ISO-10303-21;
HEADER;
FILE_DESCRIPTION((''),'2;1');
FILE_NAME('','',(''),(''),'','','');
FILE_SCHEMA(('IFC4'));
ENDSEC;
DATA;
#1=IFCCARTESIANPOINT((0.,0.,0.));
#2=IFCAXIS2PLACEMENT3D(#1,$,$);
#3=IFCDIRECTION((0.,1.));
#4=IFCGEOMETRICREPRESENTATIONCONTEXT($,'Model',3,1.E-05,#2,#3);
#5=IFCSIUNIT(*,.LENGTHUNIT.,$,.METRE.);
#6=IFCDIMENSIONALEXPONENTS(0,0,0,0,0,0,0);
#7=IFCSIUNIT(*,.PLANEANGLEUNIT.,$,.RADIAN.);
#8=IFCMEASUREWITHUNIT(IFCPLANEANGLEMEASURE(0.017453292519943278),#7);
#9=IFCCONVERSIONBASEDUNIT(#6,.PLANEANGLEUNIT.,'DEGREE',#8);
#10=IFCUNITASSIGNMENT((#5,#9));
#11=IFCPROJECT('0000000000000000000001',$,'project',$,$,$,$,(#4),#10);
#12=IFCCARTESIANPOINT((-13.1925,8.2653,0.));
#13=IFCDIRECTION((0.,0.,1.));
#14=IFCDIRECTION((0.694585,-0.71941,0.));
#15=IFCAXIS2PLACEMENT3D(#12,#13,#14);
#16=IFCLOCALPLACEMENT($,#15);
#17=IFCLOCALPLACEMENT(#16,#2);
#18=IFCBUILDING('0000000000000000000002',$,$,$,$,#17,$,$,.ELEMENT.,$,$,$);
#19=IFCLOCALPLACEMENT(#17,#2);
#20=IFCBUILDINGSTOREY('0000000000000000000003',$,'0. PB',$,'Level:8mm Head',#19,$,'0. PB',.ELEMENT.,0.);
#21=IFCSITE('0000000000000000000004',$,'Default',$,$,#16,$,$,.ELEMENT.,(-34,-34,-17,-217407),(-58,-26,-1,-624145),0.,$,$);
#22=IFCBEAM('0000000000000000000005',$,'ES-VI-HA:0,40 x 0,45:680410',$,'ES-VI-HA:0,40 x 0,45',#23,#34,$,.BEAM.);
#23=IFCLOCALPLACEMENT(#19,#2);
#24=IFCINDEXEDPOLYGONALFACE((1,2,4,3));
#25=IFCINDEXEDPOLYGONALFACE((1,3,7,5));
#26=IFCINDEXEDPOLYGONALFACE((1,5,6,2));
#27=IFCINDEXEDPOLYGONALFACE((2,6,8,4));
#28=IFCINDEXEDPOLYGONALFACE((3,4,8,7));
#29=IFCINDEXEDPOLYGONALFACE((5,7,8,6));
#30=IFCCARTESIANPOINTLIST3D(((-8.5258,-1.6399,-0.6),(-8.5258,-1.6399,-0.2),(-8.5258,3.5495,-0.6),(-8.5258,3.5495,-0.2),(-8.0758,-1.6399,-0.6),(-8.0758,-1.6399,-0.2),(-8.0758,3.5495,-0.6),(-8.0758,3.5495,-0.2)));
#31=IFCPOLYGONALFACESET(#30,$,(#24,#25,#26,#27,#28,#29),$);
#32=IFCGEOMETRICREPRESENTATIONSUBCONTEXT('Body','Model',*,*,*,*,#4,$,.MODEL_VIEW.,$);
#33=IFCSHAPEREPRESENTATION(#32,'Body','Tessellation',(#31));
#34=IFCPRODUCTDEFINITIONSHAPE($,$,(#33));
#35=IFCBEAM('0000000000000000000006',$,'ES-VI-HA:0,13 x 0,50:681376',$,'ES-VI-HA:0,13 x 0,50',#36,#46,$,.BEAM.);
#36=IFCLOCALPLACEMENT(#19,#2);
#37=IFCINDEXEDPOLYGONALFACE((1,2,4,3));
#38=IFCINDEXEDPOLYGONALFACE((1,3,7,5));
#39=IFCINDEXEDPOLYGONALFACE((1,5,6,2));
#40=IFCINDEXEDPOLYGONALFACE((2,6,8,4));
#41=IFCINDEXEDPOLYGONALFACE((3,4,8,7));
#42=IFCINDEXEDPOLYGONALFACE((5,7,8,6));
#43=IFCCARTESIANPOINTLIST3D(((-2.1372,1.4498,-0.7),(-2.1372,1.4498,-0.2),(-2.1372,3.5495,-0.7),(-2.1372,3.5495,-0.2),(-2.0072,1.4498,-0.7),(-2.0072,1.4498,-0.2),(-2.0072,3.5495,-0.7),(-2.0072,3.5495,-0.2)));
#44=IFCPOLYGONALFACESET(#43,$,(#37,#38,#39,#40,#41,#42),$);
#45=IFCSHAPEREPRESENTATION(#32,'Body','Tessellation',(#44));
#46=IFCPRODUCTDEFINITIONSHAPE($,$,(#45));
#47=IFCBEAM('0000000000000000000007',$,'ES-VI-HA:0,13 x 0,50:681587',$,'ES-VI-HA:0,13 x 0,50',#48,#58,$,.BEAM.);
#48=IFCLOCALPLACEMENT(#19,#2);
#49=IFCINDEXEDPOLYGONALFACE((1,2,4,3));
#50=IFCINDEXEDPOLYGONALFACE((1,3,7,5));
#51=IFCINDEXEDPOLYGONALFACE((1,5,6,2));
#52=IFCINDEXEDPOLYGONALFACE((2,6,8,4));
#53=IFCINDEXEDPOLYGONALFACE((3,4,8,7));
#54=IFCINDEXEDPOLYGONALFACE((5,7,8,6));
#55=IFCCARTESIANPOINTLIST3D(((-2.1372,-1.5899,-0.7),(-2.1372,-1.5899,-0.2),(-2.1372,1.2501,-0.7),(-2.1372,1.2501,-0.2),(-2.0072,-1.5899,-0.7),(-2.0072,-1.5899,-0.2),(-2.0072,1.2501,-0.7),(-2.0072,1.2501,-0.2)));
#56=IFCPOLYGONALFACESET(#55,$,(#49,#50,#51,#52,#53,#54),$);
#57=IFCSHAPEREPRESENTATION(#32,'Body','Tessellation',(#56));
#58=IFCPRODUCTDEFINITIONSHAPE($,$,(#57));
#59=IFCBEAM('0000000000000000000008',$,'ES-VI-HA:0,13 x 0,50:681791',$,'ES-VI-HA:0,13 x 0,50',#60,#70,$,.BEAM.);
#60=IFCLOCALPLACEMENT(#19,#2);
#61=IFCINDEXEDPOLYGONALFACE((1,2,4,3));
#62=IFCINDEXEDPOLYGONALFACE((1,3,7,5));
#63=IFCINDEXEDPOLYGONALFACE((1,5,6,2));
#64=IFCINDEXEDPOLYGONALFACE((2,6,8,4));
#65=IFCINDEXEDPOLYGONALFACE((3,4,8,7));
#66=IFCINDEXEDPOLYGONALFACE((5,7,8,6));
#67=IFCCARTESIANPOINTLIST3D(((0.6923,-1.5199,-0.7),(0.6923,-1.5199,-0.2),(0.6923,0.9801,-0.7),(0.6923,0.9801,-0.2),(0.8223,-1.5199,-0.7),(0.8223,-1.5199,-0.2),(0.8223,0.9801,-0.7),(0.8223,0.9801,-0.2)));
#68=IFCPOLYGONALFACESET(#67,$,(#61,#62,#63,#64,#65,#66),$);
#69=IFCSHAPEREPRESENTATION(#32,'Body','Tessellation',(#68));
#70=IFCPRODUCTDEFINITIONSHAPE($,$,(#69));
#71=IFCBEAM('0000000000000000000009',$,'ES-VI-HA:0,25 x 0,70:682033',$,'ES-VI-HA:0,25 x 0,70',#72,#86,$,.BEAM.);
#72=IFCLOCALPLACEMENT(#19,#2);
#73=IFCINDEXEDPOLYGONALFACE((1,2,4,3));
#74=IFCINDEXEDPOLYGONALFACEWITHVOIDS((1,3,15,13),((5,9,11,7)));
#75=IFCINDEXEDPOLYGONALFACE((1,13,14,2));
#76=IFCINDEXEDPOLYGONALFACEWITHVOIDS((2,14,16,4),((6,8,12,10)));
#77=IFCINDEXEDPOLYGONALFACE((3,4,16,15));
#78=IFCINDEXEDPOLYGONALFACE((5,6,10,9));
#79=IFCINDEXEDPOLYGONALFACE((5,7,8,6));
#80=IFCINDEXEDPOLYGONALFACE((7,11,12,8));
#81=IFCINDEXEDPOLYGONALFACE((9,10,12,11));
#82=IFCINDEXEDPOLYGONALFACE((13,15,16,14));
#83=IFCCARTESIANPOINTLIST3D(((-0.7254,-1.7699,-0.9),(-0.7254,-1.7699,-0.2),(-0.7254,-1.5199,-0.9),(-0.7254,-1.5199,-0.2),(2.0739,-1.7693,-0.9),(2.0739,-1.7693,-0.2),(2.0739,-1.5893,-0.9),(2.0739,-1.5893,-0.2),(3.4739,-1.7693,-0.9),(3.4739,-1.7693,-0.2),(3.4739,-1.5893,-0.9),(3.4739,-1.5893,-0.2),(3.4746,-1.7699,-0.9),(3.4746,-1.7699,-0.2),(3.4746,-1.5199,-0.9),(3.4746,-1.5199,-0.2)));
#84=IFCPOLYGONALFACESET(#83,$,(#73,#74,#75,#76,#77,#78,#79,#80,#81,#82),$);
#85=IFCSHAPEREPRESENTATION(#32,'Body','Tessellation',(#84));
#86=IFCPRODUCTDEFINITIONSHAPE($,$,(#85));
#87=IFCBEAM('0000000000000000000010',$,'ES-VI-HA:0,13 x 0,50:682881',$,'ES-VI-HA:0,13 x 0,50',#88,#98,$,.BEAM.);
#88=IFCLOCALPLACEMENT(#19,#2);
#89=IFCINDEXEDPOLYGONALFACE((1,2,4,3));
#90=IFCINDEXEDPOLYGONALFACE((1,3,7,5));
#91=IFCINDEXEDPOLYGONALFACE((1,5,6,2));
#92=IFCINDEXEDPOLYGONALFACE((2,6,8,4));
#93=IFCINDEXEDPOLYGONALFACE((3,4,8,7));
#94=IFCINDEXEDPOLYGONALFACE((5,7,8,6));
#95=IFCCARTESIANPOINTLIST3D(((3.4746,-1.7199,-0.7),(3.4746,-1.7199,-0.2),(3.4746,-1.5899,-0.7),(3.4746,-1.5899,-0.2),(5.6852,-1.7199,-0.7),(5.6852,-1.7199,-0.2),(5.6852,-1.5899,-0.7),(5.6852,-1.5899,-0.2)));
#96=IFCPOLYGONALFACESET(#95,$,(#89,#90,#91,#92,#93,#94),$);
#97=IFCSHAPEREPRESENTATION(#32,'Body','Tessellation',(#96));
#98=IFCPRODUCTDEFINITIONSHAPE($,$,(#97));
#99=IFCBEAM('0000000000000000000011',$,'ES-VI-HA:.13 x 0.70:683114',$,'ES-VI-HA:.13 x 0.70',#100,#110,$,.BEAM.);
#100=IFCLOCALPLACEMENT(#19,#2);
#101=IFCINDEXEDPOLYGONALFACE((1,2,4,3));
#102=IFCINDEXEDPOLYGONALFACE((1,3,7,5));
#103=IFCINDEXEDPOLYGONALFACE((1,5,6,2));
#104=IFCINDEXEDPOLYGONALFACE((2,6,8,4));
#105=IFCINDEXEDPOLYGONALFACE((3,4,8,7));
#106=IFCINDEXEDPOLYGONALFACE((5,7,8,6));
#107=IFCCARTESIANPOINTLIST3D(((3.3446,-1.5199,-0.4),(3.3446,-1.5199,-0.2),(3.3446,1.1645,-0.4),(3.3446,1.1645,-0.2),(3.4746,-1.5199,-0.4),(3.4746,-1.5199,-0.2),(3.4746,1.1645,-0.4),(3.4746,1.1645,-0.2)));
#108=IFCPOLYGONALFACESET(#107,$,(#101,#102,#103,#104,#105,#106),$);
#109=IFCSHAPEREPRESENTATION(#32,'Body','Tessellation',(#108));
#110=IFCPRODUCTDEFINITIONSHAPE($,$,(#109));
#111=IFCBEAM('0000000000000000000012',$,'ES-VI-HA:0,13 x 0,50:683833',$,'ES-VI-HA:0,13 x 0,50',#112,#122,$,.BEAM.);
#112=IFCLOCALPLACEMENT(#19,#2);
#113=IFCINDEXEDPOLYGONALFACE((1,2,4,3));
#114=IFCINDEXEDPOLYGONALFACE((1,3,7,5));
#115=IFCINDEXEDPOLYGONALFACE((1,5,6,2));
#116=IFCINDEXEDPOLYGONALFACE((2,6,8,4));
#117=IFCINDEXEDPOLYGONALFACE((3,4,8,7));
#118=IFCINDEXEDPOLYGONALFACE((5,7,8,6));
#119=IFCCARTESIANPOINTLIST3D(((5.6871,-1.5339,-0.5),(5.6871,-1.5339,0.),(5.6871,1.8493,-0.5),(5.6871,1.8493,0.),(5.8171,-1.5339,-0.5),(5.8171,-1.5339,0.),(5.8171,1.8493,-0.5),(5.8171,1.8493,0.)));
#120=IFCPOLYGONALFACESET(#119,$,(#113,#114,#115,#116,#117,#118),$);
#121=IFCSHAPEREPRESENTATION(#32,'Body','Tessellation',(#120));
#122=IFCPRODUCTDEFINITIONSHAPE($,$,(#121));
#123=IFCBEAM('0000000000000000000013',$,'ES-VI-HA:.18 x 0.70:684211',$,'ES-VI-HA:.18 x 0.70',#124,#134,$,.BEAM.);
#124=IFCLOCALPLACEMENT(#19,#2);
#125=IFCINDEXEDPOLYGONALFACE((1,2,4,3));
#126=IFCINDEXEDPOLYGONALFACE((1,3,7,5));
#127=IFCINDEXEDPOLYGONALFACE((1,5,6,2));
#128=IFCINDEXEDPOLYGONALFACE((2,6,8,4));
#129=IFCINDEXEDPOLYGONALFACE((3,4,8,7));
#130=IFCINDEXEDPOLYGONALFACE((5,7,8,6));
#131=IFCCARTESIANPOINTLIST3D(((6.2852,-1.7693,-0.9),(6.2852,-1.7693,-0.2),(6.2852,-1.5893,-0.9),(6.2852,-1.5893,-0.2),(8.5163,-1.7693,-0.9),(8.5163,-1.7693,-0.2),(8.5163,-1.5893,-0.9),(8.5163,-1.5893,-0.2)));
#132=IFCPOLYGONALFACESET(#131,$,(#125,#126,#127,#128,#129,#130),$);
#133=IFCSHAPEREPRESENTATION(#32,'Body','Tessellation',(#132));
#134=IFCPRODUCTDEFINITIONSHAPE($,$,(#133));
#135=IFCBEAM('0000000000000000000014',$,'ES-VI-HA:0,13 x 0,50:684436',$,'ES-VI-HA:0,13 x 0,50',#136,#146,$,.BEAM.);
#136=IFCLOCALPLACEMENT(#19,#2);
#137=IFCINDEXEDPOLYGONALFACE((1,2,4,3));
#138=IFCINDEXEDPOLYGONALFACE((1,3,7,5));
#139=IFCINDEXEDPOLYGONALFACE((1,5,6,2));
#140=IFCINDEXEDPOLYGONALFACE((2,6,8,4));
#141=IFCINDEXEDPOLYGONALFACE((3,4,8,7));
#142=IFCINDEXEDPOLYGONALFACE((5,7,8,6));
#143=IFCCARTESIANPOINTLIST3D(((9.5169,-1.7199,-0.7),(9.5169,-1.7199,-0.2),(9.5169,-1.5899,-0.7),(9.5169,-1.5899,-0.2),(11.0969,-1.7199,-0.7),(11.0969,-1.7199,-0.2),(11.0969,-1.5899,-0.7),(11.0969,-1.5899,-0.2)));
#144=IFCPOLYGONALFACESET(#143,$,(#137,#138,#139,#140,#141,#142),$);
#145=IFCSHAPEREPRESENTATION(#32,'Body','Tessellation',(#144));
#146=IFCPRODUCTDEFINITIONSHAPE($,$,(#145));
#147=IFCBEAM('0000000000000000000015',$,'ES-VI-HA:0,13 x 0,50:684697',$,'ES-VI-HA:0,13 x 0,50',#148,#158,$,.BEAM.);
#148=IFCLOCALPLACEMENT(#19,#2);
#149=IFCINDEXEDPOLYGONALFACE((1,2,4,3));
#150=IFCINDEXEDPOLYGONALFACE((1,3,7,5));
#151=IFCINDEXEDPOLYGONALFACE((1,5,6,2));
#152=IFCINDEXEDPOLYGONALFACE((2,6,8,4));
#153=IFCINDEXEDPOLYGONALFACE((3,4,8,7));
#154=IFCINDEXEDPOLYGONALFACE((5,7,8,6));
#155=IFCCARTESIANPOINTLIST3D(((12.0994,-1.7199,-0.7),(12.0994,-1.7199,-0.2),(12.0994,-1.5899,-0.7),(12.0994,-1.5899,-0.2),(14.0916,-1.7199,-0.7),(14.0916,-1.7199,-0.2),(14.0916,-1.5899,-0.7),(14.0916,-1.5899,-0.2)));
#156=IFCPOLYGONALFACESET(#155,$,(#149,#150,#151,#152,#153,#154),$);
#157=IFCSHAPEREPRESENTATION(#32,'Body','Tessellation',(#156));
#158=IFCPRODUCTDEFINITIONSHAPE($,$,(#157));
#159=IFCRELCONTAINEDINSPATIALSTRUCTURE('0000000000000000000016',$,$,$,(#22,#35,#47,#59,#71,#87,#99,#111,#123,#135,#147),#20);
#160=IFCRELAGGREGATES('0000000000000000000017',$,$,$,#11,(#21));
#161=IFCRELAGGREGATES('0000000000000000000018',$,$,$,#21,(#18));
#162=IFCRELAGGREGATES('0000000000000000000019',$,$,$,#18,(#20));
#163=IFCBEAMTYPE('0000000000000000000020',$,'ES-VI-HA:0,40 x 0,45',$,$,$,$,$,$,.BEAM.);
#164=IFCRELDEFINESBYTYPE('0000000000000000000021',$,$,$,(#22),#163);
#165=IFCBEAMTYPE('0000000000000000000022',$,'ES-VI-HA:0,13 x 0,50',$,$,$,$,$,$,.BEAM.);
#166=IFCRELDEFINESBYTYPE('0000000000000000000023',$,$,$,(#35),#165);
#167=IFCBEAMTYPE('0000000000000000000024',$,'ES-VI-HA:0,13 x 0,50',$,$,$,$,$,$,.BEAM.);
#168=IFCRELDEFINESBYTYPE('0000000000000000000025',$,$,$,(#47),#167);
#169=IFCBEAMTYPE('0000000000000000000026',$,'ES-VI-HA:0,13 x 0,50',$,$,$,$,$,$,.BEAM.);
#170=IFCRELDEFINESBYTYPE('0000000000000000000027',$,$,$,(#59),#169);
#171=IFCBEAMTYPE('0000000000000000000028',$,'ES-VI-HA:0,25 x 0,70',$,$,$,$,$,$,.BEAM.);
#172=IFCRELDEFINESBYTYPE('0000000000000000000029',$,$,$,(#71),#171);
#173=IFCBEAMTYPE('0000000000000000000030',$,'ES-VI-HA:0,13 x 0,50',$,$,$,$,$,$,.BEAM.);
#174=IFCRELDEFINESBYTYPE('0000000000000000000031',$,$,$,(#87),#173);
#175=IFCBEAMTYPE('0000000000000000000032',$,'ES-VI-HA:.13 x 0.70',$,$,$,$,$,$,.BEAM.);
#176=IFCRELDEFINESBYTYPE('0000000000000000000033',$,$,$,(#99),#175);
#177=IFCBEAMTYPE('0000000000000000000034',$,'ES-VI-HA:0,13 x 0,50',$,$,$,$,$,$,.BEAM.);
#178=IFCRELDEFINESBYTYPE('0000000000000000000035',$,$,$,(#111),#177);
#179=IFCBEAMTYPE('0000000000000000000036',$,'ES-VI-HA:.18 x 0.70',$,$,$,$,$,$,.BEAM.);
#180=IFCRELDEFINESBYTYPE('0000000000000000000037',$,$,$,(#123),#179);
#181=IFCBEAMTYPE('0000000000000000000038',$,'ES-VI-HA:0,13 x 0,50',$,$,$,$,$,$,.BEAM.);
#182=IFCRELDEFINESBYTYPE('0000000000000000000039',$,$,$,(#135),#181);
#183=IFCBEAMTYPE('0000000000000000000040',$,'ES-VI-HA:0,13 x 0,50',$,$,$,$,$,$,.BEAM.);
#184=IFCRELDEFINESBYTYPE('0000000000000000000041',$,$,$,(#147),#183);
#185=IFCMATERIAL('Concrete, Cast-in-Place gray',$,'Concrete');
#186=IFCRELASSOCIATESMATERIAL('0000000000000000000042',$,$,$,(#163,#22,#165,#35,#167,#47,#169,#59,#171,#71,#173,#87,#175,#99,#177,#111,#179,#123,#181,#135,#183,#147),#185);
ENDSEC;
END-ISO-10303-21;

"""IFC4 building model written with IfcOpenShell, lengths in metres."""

from ifc_helpers import new_model, entity, si_unit, converted_unit, direction, frame, origin, place, context, subcontext, project, spatial, indexed_curve, outline, extrude, source, transform, mapped, material, type_object, type_shapes, element, save


model = new_model("IFC4")

# Units and contexts
model_context = context("Model", 3, precision=1e-05, world=origin(), true_north=direction((0.0, 1.0)))
body_context = subcontext(model_context, "Body", "Model", "MODEL_VIEW")
ifc_project = project(units=[si_unit("LENGTHUNIT", "METRE"), converted_unit("PLANEANGLEUNIT", "DEGREE", entity("IfcPlaneAngleMeasure", 0.017453292519943278), si_unit("PLANEANGLEUNIT", "RADIAN"), dimensions=[0, 0, 0, 0, 0, 0, 0])], contexts=[model_context])

# Site, building, storey
site_placement = place(None, frame((-13.1925, 8.2653, 0.0), z_axis=(0.0, 0.0, 1.0), x_axis=(0.694585, -0.71941, 0.0)))
site = spatial("IfcSite", under=ifc_project, at=site_placement, Name="Default", CompositionType="ELEMENT", RefLatitude=(-34, -34, -17, -217407), RefLongitude=(-58, -26, -1, -624145), RefElevation=0.0)
building_placement = place(site_placement, origin())
building = spatial("IfcBuilding", under=site, at=building_placement, CompositionType="ELEMENT")
storey_placement = place(building_placement, origin())
storey = spatial("IfcBuildingStorey", under=building, at=storey_placement, Name="0. PB", ObjectType="Level:8mm Head", LongName="0. PB", CompositionType="ELEMENT", Elevation=0.0)

# Beams
ifc_material_1 = material(Name="Concrete, Cast-in-Place gray", Category="Concrete")
beam_type_1 = type_object("IfcBeamType", Name="ES-VI-HA:0,40 x 0,45", PredefinedType="BEAM", material=ifc_material_1)
shared_shape_1 = source(origin(), body_context, "Body", "SweptSolid", [
    extrude(outline(indexed_curve([(-0.225, -0.2), (0.225, -0.2), (0.225, 0.2), (-0.225, 0.2), (-0.225, -0.2)], self_intersect=False)), frame((-8.3008, 3.5495, -0.4), z_axis=(0.0, -1.0, 0.0), x_axis=(-1.0, 0.0, 0.0)), (0.0, 0.0, 1.0), 5.1894),
])
type_shapes(beam_type_1, [shared_shape_1])
beam_1_placement = place(storey_placement, origin())
element("IfcBeam", 1, at=beam_1_placement, inside=storey, type_object=beam_type_1, material=ifc_material_1, Name="ES-VI-HA:0,40 x 0,45:680410", ObjectType="ES-VI-HA:0,40 x 0,45", PredefinedType="BEAM", context=body_context, shape_type="MappedRepresentation", body=[
    mapped(shared_shape_1, transform((0.0, 0.0, 0.0), scale=1.0)),
])
beam_type_2 = type_object("IfcBeamType", Name="ES-VI-HA:0,13 x 0,50", PredefinedType="BEAM", material=ifc_material_1)
shared_shape_2 = source(origin(), body_context, "Body", "SweptSolid", [
    extrude(outline(indexed_curve([(-0.065, -0.25), (0.065, -0.25), (0.065, 0.25), (-0.065, 0.25), (-0.065, -0.25)], self_intersect=False)), frame((-2.0722, 3.5495, -0.45), z_axis=(0.0, -1.0, 0.0), x_axis=(-1.0, 0.0, 0.0)), (0.0, 0.0, 1.0), 2.0997),
])
type_shapes(beam_type_2, [shared_shape_2])
beam_2_placement = place(storey_placement, origin())
element("IfcBeam", 2, at=beam_2_placement, inside=storey, type_object=beam_type_2, material=ifc_material_1, Name="ES-VI-HA:0,13 x 0,50:681376", ObjectType="ES-VI-HA:0,13 x 0,50", PredefinedType="BEAM", context=body_context, shape_type="MappedRepresentation", body=[
    mapped(shared_shape_2, transform((0.0, 0.0, 0.0), scale=1.0)),
])
beam_type_3 = type_object("IfcBeamType", Name="ES-VI-HA:0,13 x 0,50", PredefinedType="BEAM", material=ifc_material_1)
shared_shape_3 = source(origin(), body_context, "Body", "SweptSolid", [
    extrude(outline(indexed_curve([(-0.065, -0.25), (0.065, -0.25), (0.065, 0.25), (-0.065, 0.25), (-0.065, -0.25)], self_intersect=False)), frame((-2.0722, 1.2501, -0.45), z_axis=(0.0, -1.0, 0.0), x_axis=(-1.0, 0.0, 0.0)), (0.0, 0.0, 1.0), 2.84),
])
type_shapes(beam_type_3, [shared_shape_3])
beam_3_placement = place(storey_placement, origin())
element("IfcBeam", 3, at=beam_3_placement, inside=storey, type_object=beam_type_3, material=ifc_material_1, Name="ES-VI-HA:0,13 x 0,50:681587", ObjectType="ES-VI-HA:0,13 x 0,50", PredefinedType="BEAM", context=body_context, shape_type="MappedRepresentation", body=[
    mapped(shared_shape_3, transform((0.0, 0.0, 0.0), scale=1.0)),
])
beam_type_4 = type_object("IfcBeamType", Name="ES-VI-HA:0,13 x 0,50", PredefinedType="BEAM", material=ifc_material_1)
shared_shape_4 = source(origin(), body_context, "Body", "SweptSolid", [
    extrude(outline(indexed_curve([(-0.065, -0.25), (0.065, -0.25), (0.065, 0.25), (-0.065, 0.25), (-0.065, -0.25)], self_intersect=False)), frame((0.7573, -1.5199, -0.45), z_axis=(0.0, 1.0, 0.0), x_axis=(-1.0, 0.0, 0.0)), (0.0, 0.0, 1.0), 2.5),
])
type_shapes(beam_type_4, [shared_shape_4])
beam_4_placement = place(storey_placement, origin())
element("IfcBeam", 4, at=beam_4_placement, inside=storey, type_object=beam_type_4, material=ifc_material_1, Name="ES-VI-HA:0,13 x 0,50:681791", ObjectType="ES-VI-HA:0,13 x 0,50", PredefinedType="BEAM", context=body_context, shape_type="MappedRepresentation", body=[
    mapped(shared_shape_4, transform((0.0, 0.0, 0.0), scale=1.0)),
])

# Beam, opening
beam_type_5 = type_object("IfcBeamType", Name="ES-VI-HA:0,25 x 0,70", PredefinedType="BEAM", material=ifc_material_1)
shared_shape_5 = source(origin(), body_context, "Body", "SweptSolid", [
    extrude(outline(indexed_curve([(-0.125, -0.35), (0.125, -0.35), (0.125, 0.35), (-0.125, 0.35), (-0.125, -0.35)], self_intersect=False)), frame((-0.7254, -1.6449, -0.55), z_axis=(1.0, 0.0, 0.0), x_axis=(0.0, -1.0, 0.0)), (0.0, 0.0, 1.0), 4.2),
])
type_shapes(beam_type_5, [shared_shape_5])
beam_5_placement = place(storey_placement, origin())
beam_5 = element("IfcBeam", 5, at=beam_5_placement, inside=storey, type_object=beam_type_5, material=ifc_material_1, Name="ES-VI-HA:0,25 x 0,70:682033", ObjectType="ES-VI-HA:0,25 x 0,70", PredefinedType="BEAM", context=body_context, shape_type="MappedRepresentation", body=[
    mapped(shared_shape_5, transform((0.0, 0.0, 0.0), scale=1.0)),
])
opening_1_placement = place(storey_placement, origin())
element("IfcOpeningElement", 6, at=opening_1_placement, cuts=beam_5, PredefinedType="OPENING", context=body_context, shape_type="SweptSolid", body=[
    extrude(outline(indexed_curve([(-0.09, -0.7), (0.09, -0.7), (0.09, 0.7), (-0.09, 0.7), (-0.09, -0.7)], self_intersect=False)), frame((2.7739, -1.6793, -0.9), z_axis=(0.0, 0.0, 1.0), x_axis=(0.0, 1.0, 0.0)), (0.0, 0.0, 1.0), 0.7),
])

# Beams
beam_type_6 = type_object("IfcBeamType", Name="ES-VI-HA:0,13 x 0,50", PredefinedType="BEAM", material=ifc_material_1)
shared_shape_6 = source(origin(), body_context, "Body", "SweptSolid", [
    extrude(outline(indexed_curve([(-0.25, -0.065), (0.25, -0.065), (0.25, 0.065), (-0.25, 0.065), (-0.25, -0.065)], self_intersect=False)), frame((3.4746, -1.6549, -0.45), z_axis=(1.0, 0.0, 0.0), x_axis=(0.0, 0.0, -1.0)), (0.0, 0.0, 1.0), 2.2106),
])
type_shapes(beam_type_6, [shared_shape_6])
beam_6_placement = place(storey_placement, origin())
element("IfcBeam", 7, at=beam_6_placement, inside=storey, type_object=beam_type_6, material=ifc_material_1, Name="ES-VI-HA:0,13 x 0,50:682881", ObjectType="ES-VI-HA:0,13 x 0,50", PredefinedType="BEAM", context=body_context, shape_type="MappedRepresentation", body=[
    mapped(shared_shape_6, transform((0.0, 0.0, 0.0), scale=1.0)),
])
beam_type_7 = type_object("IfcBeamType", Name="ES-VI-HA:.13 x 0.70", PredefinedType="BEAM", material=ifc_material_1)
shared_shape_7 = source(origin(), body_context, "Body", "SweptSolid", [
    extrude(outline(indexed_curve([(-0.065, -0.1), (0.065, -0.1), (0.065, 0.1), (-0.065, 0.1), (-0.065, -0.1)], self_intersect=False)), frame((3.4096, -1.5199, -0.3), z_axis=(0.0, 1.0, 0.0), x_axis=(-1.0, 0.0, 0.0)), (0.0, 0.0, 1.0), 2.6844),
])
type_shapes(beam_type_7, [shared_shape_7])
beam_7_placement = place(storey_placement, origin())
element("IfcBeam", 8, at=beam_7_placement, inside=storey, type_object=beam_type_7, material=ifc_material_1, Name="ES-VI-HA:.13 x 0.70:683114", ObjectType="ES-VI-HA:.13 x 0.70", PredefinedType="BEAM", context=body_context, shape_type="MappedRepresentation", body=[
    mapped(shared_shape_7, transform((0.0, 0.0, 0.0), scale=1.0)),
])
beam_type_8 = type_object("IfcBeamType", Name="ES-VI-HA:0,13 x 0,50", PredefinedType="BEAM", material=ifc_material_1)
shared_shape_8 = source(origin(), body_context, "Body", "SweptSolid", [
    extrude(outline(indexed_curve([(-0.065, -0.25), (0.065, -0.25), (0.065, 0.25), (-0.065, 0.25), (-0.065, -0.25)], self_intersect=False)), frame((5.7521, 1.8493, -0.25), z_axis=(0.0, -1.0, 0.0), x_axis=(-1.0, 0.0, 0.0)), (0.0, 0.0, 1.0), 3.3832),
])
type_shapes(beam_type_8, [shared_shape_8])
beam_8_placement = place(storey_placement, origin())
element("IfcBeam", 9, at=beam_8_placement, inside=storey, type_object=beam_type_8, material=ifc_material_1, Name="ES-VI-HA:0,13 x 0,50:683833", ObjectType="ES-VI-HA:0,13 x 0,50", PredefinedType="BEAM", context=body_context, shape_type="MappedRepresentation", body=[
    mapped(shared_shape_8, transform((0.0, 0.0, 0.0), scale=1.0)),
])
beam_type_9 = type_object("IfcBeamType", Name="ES-VI-HA:.18 x 0.70", PredefinedType="BEAM", material=ifc_material_1)
shared_shape_9 = source(origin(), body_context, "Body", "SweptSolid", [
    extrude(outline(indexed_curve([(-0.35, -0.09), (0.35, -0.09), (0.35, 0.09), (-0.35, 0.09), (-0.35, -0.09)], self_intersect=False)), frame((6.2852, -1.6793, -0.55), z_axis=(1.0, 0.0, 0.0), x_axis=(0.0, 0.0, -1.0)), (0.0, 0.0, 1.0), 2.2311),
])
type_shapes(beam_type_9, [shared_shape_9])
beam_9_placement = place(storey_placement, origin())
element("IfcBeam", 10, at=beam_9_placement, inside=storey, type_object=beam_type_9, material=ifc_material_1, Name="ES-VI-HA:.18 x 0.70:684211", ObjectType="ES-VI-HA:.18 x 0.70", PredefinedType="BEAM", context=body_context, shape_type="MappedRepresentation", body=[
    mapped(shared_shape_9, transform((0.0, 0.0, 0.0), scale=1.0)),
])
beam_type_10 = type_object("IfcBeamType", Name="ES-VI-HA:0,13 x 0,50", PredefinedType="BEAM", material=ifc_material_1)
shared_shape_10 = source(origin(), body_context, "Body", "SweptSolid", [
    extrude(outline(indexed_curve([(-0.25, -0.065), (0.25, -0.065), (0.25, 0.065), (-0.25, 0.065), (-0.25, -0.065)], self_intersect=False)), frame((9.5169, -1.6549, -0.45), z_axis=(1.0, 0.0, 0.0), x_axis=(0.0, 0.0, -1.0)), (0.0, 0.0, 1.0), 1.58),
])
type_shapes(beam_type_10, [shared_shape_10])
beam_10_placement = place(storey_placement, origin())
element("IfcBeam", 11, at=beam_10_placement, inside=storey, type_object=beam_type_10, material=ifc_material_1, Name="ES-VI-HA:0,13 x 0,50:684436", ObjectType="ES-VI-HA:0,13 x 0,50", PredefinedType="BEAM", context=body_context, shape_type="MappedRepresentation", body=[
    mapped(shared_shape_10, transform((0.0, 0.0, 0.0), scale=1.0)),
])
beam_type_11 = type_object("IfcBeamType", Name="ES-VI-HA:0,13 x 0,50", PredefinedType="BEAM", material=ifc_material_1)
shared_shape_11 = source(origin(), body_context, "Body", "SweptSolid", [
    extrude(outline(indexed_curve([(-0.25, -0.065), (0.25, -0.065), (0.25, 0.065), (-0.25, 0.065), (-0.25, -0.065)], self_intersect=False)), frame((12.0994, -1.6549, -0.45), z_axis=(1.0, 0.0, 0.0), x_axis=(0.0, 0.0, -1.0)), (0.0, 0.0, 1.0), 1.9922),
])
type_shapes(beam_type_11, [shared_shape_11])
beam_11_placement = place(storey_placement, origin())
element("IfcBeam", 12, at=beam_11_placement, inside=storey, type_object=beam_type_11, material=ifc_material_1, Name="ES-VI-HA:0,13 x 0,50:684697", ObjectType="ES-VI-HA:0,13 x 0,50", PredefinedType="BEAM", context=body_context, shape_type="MappedRepresentation", body=[
    mapped(shared_shape_11, transform((0.0, 0.0, 0.0), scale=1.0)),
])

save(model, "model.ifc")
